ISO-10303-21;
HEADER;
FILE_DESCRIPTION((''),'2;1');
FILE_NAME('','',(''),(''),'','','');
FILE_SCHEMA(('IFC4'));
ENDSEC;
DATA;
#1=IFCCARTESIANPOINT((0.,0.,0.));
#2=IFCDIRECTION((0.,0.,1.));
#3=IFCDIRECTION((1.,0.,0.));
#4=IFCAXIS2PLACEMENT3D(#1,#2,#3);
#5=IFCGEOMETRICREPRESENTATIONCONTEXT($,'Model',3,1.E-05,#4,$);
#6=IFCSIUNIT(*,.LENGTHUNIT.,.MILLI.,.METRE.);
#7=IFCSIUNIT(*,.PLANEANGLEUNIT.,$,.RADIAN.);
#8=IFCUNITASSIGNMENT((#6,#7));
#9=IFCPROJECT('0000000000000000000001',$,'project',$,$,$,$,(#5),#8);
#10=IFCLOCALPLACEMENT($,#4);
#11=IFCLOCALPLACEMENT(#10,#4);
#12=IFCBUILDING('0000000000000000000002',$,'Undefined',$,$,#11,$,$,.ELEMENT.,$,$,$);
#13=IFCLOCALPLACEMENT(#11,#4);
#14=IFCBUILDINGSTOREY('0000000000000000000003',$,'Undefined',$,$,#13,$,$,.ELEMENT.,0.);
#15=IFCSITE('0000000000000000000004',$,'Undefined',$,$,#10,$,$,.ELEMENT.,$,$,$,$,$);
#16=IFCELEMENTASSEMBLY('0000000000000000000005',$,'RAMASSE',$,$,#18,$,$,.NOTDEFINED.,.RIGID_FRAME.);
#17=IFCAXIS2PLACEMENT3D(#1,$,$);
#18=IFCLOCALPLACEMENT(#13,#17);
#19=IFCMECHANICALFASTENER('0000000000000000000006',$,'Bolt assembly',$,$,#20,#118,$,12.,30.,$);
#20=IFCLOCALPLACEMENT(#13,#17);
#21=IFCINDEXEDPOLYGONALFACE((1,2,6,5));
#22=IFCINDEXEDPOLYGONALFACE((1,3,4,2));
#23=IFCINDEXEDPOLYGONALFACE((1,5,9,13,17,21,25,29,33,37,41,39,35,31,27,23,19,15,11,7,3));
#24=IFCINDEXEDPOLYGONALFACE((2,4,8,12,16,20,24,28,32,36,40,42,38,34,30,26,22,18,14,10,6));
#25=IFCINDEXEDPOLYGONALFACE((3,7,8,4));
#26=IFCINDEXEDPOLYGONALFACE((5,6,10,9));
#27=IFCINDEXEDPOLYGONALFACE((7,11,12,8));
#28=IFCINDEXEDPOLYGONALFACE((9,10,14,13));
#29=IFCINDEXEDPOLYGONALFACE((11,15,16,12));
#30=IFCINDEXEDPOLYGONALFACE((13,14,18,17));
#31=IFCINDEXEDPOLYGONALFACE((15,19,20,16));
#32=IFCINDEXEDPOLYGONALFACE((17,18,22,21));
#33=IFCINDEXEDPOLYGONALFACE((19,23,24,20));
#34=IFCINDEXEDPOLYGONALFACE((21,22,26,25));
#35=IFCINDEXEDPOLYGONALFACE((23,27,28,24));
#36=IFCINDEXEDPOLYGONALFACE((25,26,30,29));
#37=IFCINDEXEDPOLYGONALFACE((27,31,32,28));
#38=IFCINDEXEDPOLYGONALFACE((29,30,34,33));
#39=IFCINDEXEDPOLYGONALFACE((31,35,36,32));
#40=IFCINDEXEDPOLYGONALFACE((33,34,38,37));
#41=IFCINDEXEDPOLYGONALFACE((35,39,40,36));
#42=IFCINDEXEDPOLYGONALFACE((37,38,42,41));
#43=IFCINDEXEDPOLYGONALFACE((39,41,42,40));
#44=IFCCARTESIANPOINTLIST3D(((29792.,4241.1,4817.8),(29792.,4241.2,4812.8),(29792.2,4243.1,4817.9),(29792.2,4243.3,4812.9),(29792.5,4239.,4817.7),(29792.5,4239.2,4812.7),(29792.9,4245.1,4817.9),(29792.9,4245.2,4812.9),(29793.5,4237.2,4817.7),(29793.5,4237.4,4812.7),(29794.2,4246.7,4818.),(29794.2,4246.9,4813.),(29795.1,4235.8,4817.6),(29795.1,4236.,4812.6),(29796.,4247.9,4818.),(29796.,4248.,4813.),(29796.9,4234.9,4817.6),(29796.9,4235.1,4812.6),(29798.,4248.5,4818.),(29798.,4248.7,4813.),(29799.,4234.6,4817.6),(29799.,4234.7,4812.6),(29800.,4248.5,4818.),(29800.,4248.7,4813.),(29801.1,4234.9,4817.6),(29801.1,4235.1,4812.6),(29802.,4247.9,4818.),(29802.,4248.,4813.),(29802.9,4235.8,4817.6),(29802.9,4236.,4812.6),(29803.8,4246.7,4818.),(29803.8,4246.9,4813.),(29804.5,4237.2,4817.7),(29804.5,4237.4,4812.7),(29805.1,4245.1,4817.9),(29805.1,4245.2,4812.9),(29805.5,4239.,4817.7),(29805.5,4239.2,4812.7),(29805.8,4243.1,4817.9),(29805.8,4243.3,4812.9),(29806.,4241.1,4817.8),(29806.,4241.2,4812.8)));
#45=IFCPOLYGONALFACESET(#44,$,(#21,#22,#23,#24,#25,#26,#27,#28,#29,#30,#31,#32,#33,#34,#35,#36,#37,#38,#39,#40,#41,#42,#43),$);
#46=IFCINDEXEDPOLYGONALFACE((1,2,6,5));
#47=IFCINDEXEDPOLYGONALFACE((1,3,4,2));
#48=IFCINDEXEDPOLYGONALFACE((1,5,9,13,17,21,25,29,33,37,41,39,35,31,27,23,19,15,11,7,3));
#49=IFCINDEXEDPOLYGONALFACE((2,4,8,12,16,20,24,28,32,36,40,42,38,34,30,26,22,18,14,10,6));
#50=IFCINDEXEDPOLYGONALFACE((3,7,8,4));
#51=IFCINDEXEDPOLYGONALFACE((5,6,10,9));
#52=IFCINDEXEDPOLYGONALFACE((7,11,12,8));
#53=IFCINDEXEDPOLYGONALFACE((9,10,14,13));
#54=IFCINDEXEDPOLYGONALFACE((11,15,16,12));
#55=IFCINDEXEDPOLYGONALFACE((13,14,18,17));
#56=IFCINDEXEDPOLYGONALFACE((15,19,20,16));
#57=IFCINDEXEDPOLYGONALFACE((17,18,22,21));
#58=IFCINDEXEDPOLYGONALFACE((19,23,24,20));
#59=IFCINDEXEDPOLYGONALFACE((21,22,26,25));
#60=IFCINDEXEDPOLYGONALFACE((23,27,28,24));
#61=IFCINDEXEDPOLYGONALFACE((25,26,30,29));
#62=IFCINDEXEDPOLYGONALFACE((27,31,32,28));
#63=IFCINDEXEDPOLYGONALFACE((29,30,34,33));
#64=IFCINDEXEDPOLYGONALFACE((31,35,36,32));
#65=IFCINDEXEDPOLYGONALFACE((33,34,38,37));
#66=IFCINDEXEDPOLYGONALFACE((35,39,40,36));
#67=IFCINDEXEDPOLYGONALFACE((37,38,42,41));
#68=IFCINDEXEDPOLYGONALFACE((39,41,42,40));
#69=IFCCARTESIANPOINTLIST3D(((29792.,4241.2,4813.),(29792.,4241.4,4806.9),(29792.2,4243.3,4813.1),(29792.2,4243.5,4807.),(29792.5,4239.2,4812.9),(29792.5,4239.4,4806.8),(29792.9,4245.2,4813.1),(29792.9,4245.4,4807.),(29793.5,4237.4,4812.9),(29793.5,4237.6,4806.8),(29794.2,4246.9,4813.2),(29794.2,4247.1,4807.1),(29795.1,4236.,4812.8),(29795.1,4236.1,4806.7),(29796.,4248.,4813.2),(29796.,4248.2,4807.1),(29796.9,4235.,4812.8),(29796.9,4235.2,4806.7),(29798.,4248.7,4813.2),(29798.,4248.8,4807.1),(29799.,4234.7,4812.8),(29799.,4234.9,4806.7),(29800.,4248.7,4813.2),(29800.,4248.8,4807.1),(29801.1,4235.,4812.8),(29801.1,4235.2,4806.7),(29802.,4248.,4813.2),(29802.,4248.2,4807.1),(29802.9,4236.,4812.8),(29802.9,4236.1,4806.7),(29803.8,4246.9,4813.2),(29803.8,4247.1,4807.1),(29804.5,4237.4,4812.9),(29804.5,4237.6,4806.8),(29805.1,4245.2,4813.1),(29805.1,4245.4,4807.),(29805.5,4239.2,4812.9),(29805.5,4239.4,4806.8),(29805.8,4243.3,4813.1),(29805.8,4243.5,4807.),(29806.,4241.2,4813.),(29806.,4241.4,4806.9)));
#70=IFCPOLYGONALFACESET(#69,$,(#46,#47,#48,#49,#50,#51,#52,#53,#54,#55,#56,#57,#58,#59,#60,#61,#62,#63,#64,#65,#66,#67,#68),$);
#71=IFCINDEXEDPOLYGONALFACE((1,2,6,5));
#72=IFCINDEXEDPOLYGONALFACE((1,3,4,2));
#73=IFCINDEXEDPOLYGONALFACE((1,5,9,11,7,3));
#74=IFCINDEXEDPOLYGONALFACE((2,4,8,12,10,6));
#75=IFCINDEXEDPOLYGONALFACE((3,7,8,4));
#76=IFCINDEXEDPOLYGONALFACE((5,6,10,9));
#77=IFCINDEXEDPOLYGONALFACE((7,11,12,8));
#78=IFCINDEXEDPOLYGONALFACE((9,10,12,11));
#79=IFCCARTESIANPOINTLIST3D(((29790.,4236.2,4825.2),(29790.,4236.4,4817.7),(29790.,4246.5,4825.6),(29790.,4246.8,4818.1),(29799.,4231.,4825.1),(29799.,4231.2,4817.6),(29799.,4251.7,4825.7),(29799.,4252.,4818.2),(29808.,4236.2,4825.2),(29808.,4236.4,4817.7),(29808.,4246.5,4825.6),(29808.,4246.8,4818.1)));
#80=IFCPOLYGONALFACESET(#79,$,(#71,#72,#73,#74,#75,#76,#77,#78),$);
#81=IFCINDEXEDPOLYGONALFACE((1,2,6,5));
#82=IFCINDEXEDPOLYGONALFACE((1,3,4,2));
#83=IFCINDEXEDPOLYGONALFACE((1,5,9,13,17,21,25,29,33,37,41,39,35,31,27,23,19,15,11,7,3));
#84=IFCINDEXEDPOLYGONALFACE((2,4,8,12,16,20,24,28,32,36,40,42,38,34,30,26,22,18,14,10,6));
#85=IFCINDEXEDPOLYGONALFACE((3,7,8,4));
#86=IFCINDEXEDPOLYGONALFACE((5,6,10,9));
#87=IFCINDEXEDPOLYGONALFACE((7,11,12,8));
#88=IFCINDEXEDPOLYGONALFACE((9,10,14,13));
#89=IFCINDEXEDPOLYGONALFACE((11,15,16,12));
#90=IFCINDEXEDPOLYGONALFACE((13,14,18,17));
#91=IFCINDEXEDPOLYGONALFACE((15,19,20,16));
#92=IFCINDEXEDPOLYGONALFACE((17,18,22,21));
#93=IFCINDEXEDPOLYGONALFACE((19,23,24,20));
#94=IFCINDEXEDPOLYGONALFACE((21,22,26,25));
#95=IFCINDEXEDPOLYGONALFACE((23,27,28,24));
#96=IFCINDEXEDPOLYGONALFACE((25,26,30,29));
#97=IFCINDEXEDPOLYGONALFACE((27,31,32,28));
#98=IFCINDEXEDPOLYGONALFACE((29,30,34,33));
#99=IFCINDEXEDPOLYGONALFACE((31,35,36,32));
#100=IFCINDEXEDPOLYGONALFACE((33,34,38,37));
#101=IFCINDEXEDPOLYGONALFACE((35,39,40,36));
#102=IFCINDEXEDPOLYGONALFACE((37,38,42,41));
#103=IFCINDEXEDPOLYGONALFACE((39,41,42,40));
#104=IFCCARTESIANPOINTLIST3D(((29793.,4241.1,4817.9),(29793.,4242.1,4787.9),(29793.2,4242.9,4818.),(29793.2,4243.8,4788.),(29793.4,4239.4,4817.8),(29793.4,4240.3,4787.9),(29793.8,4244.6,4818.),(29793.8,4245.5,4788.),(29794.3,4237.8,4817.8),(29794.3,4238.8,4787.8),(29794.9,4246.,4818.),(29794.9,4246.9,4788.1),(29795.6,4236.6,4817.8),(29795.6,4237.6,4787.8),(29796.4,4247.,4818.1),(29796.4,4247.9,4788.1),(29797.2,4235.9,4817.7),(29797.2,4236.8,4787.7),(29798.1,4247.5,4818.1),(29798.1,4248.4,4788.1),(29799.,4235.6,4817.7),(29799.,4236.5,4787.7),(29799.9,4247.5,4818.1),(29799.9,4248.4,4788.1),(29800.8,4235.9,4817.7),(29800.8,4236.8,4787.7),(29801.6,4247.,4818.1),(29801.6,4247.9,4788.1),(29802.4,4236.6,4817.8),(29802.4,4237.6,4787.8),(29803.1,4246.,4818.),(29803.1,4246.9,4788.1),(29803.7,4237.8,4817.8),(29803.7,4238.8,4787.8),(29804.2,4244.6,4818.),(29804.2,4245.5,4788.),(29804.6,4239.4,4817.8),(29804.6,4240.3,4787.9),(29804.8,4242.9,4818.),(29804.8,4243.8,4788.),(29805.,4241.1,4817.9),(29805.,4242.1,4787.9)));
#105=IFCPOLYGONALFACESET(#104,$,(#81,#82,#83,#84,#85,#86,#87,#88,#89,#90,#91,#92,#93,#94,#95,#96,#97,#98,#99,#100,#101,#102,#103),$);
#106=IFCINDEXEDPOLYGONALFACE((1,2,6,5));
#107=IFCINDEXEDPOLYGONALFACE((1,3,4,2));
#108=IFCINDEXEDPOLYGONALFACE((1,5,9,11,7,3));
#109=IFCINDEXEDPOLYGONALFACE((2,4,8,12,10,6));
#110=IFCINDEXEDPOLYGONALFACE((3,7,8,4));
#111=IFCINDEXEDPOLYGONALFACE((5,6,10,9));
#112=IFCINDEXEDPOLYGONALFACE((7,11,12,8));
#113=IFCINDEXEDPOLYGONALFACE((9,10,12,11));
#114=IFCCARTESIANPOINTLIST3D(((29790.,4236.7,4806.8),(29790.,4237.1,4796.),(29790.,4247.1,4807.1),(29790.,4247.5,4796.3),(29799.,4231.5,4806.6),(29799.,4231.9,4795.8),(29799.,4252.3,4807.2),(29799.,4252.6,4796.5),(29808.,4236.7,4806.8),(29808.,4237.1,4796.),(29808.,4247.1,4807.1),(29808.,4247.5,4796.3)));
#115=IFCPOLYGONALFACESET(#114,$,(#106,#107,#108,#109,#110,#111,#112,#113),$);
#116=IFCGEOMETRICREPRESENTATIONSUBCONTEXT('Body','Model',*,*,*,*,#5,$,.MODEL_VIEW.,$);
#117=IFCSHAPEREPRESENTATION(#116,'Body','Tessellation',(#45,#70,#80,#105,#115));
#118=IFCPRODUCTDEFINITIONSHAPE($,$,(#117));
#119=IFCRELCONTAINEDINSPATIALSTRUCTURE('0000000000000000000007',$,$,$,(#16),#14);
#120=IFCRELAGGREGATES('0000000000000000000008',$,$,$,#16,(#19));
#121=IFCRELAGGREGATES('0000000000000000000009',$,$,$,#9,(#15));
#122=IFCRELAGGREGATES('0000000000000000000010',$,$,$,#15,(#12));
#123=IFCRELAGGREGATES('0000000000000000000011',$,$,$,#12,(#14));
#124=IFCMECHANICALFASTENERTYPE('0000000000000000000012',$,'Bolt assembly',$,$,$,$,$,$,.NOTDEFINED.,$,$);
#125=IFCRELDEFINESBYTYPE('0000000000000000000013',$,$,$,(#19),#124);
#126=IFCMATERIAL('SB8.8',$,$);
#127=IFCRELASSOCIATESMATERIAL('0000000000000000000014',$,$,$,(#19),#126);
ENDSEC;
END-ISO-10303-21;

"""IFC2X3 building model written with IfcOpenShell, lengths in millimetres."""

from ifc_helpers import new_model, si_unit, frame, origin_with_axes, origin_2d_with_axis, place, context, subcontext, project, spatial, polyline, circle, outline, extrude, source, transform, mapped, material, type_object, element, aggregate, save


model = new_model("IFC2X3")

# Units and contexts
model_context = context("Model", 3, precision=1e-05, world=origin_with_axes())
body_context = subcontext(model_context, "Body", "Model", "MODEL_VIEW")
ifc_project = project(units=[si_unit("LENGTHUNIT", "METRE", prefix="MILLI"), si_unit("PLANEANGLEUNIT", "RADIAN")], contexts=[model_context])

# Site, building, storey
site_placement = place(None, origin_with_axes())
site = spatial("IfcSite", under=ifc_project, at=site_placement, Name="Undefined", CompositionType="ELEMENT")
building_placement = place(site_placement, origin_with_axes())
building = spatial("IfcBuilding", under=site, at=building_placement, Name="Undefined", CompositionType="ELEMENT")
storey_placement = place(building_placement, origin_with_axes())
storey = spatial("IfcBuildingStorey", under=building, at=storey_placement, Name="Undefined", CompositionType="ELEMENT", Elevation=0.0)

# Element assembly
assembly_1_placement = place(storey_placement, origin_with_axes())
assembly_1 = element("IfcElementAssembly", 1, at=assembly_1_placement, inside=storey, Name="RAMASSE", AssemblyPlace="NOTDEFINED", PredefinedType="RIGID_FRAME")

# Shared definitions
ifc_material_1 = material(Name="SB8.8")
mechanical_fastener_type = type_object("IfcMechanicalFastenerType", Name="Bolt assembly")

# Mechanical fastener
shared_shape_1 = source(origin_with_axes(), body_context, "Body", "SweptSolid", [
    extrude(circle(Radius=7.0, at=origin_2d_with_axis()), frame((0.0, -4.9, 0.0), z_axis=(0.0, 1.0, 0.0), x_axis=(1.0, 0.0, 0.0)), (0.0, 0.0, 1.0), 5.0),
    extrude(circle(Radius=7.0, at=origin_2d_with_axis()), frame((0.0, -0.1, 0.0), z_axis=(0.0, 1.0, 0.0), x_axis=(1.0, 0.0, 0.0)), (0.0, 0.0, 1.0), 6.1),
    extrude(outline(polyline([(10.4, 0.0), (5.2, 9.0), (-5.2, 9.0), (-10.4, 0.0), (-5.2, -9.0), (5.2, -9.0), (10.4, 0.0)])), frame((0.0, -12.5, 0.0), z_axis=(0.0, 1.0, 0.0), x_axis=(1.0, 0.0, 0.0)), (0.0, 0.0, 1.0), 7.5),
    extrude(circle(Radius=6.0, at=origin_2d_with_axis()), frame((0.0, -5.0, 0.0), z_axis=(0.0, 1.0, 0.0), x_axis=(1.0, 0.0, 0.0)), (0.0, 0.0, 1.0), 30.0),
    extrude(outline(polyline([(10.4, 0.0), (5.2, 9.0), (-5.2, 9.0), (-10.4, 0.0), (-5.2, -9.0), (5.2, -9.0), (10.4, 0.0)])), frame((0.0, 6.0, 0.0), z_axis=(0.0, 1.0, 0.0), x_axis=(1.0, 0.0, 0.0)), (0.0, 0.0, 1.0), 10.8),
])
mechanical_fastener_1_placement = place(assembly_1_placement, frame((29799.0, 4241.7, 4812.9), z_axis=(1.0, 0.0, 0.0), x_axis=(0.0, -0.99952, -0.030986)))
mechanical_fastener_1 = element("IfcMechanicalFastener", 2, at=mechanical_fastener_1_placement, type_object=mechanical_fastener_type, material=ifc_material_1, Name="Bolt assembly", NominalDiameter=12.0, NominalLength=30.0, context=body_context, shape_type="MappedRepresentation", body=[
    mapped(shared_shape_1, transform((0.0, 0.0, 0.0))),
])
aggregate(assembly_1, [mechanical_fastener_1])

save(model, "model.ifc")
